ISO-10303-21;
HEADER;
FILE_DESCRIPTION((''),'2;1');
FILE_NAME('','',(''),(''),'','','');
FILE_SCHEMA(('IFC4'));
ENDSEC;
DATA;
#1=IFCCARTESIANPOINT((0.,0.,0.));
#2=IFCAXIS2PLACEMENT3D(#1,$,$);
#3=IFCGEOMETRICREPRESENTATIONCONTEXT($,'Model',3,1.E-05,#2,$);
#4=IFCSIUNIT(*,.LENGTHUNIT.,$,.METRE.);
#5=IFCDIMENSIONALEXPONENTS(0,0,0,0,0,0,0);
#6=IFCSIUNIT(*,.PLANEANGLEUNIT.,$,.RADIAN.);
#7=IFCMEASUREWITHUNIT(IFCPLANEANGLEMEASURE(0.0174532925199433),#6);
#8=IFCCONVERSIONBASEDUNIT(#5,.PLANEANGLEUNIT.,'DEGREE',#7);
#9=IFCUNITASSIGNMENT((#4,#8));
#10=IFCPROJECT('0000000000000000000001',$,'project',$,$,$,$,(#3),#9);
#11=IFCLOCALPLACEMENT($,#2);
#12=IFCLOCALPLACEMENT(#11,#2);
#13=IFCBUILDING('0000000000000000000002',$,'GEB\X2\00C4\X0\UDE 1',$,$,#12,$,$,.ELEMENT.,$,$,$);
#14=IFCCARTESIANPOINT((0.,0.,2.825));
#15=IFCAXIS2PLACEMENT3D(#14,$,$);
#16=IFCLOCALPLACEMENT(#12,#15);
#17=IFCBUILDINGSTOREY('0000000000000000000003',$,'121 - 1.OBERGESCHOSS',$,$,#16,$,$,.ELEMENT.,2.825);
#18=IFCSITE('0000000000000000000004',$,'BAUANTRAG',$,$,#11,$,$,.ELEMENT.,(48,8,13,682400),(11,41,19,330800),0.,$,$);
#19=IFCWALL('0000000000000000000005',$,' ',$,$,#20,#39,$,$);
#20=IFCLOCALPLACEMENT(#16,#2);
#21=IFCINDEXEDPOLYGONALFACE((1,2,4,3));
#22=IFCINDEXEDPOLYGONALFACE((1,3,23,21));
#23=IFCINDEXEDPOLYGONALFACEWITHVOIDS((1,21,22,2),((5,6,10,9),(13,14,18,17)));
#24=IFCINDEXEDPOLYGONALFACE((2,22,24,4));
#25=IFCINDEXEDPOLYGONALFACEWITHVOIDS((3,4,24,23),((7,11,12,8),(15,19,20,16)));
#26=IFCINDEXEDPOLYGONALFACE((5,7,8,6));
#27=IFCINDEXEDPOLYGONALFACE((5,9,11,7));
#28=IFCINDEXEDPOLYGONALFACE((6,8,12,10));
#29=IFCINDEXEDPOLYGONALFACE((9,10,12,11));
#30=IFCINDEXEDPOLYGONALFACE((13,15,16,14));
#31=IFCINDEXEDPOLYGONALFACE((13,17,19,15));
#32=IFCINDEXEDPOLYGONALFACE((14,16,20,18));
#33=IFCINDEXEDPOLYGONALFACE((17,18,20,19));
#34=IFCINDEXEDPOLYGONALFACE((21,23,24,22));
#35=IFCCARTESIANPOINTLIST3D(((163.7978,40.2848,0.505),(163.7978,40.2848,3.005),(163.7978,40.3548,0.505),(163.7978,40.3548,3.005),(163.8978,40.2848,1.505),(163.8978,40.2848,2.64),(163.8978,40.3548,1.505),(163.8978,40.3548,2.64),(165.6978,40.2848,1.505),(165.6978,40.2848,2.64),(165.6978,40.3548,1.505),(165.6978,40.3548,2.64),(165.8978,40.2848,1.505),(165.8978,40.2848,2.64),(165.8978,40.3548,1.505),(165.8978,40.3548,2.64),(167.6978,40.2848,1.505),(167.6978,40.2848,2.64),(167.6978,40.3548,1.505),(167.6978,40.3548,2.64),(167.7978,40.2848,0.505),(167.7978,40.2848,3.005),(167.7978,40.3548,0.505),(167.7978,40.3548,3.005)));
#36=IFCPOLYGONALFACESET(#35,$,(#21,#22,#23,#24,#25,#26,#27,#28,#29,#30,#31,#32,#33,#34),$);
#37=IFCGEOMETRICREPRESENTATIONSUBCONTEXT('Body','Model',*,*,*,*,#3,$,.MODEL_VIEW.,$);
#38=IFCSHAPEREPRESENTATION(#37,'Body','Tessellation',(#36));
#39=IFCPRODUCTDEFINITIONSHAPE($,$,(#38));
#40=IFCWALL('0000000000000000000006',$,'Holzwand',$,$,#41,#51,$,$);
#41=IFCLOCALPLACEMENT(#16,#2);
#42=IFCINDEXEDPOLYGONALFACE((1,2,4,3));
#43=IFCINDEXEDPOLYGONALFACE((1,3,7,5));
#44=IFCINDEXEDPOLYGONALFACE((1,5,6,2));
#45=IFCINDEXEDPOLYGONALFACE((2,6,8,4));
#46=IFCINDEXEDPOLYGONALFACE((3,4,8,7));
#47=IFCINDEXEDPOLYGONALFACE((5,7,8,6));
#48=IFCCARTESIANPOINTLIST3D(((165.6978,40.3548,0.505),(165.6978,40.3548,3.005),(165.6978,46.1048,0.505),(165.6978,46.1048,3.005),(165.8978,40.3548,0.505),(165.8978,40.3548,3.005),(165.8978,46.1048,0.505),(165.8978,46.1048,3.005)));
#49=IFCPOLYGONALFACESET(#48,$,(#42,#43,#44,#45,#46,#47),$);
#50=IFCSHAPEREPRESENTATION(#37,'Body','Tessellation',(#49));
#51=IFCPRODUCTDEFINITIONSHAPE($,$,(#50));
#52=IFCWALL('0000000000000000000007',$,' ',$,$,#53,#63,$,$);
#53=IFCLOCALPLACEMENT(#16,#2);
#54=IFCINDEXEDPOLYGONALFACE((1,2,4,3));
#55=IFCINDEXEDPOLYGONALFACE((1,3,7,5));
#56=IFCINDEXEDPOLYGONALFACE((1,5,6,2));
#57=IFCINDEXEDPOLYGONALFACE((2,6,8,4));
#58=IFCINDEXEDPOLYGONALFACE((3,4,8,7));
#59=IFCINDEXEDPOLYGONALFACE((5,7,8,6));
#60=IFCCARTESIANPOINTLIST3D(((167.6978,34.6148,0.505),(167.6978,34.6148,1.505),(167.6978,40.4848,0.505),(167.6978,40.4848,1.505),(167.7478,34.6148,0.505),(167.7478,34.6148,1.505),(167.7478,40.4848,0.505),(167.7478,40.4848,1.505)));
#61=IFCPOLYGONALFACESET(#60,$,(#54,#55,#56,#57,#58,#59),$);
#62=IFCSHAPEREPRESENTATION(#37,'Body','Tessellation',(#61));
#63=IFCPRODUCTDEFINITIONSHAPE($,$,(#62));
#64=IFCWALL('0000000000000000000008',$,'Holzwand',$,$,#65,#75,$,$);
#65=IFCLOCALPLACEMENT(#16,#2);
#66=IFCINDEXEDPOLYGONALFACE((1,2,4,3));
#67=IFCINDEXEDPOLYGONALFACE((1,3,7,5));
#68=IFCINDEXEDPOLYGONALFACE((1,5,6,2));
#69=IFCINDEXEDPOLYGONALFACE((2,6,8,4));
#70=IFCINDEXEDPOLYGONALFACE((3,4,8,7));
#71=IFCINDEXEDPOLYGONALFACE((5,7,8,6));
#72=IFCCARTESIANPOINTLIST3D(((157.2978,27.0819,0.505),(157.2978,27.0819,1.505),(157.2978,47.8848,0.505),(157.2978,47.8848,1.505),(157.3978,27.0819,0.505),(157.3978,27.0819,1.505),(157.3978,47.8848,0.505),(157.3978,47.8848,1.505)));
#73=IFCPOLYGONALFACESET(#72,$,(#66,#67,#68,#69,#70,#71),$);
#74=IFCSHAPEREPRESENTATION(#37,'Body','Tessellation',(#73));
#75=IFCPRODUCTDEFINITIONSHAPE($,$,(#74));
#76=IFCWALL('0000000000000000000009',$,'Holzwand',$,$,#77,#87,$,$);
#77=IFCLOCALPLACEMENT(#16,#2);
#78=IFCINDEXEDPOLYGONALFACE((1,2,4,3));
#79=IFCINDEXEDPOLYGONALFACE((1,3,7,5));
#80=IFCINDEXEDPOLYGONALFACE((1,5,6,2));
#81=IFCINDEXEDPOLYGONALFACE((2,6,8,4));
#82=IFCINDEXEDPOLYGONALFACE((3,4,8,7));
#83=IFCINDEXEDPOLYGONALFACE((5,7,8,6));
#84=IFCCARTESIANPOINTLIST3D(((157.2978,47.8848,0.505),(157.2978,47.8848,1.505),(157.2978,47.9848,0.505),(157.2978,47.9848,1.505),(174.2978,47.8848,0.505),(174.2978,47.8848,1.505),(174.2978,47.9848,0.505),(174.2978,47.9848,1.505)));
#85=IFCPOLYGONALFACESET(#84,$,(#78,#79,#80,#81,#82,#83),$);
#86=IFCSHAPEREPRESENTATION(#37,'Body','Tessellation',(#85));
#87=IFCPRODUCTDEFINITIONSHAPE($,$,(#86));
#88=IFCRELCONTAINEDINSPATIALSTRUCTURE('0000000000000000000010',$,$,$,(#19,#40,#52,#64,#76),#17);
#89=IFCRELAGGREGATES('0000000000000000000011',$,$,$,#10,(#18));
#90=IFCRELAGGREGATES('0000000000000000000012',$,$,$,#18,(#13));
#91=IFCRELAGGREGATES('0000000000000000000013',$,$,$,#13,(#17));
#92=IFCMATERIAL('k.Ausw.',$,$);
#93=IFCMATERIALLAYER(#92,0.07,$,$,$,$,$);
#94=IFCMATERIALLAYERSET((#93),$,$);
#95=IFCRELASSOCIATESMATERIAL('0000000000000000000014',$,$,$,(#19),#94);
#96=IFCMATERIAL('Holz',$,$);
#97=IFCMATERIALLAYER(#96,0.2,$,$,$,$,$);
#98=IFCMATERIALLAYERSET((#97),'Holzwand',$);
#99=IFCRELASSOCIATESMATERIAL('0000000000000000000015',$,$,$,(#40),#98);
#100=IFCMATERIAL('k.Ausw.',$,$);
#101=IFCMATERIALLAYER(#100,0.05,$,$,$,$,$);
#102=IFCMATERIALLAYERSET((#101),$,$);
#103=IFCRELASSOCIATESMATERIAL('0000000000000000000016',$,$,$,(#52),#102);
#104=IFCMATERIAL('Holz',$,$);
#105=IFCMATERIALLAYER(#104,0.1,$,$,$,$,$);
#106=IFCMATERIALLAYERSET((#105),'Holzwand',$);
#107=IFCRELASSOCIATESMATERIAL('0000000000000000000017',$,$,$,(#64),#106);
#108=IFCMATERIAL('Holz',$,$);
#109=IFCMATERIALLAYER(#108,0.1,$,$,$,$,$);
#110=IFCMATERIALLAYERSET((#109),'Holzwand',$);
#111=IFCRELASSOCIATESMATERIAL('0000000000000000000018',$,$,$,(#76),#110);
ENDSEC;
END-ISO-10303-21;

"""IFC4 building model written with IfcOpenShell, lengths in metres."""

from ifc_helpers import new_model, entity, si_unit, converted_unit, frame, frame_2d, origin, origin_with_axes, place, context, subcontext, project, spatial, polyline, rectangle, outline, extrude, material, layer, layer_set, layer_usage, element, save


model = new_model("IFC4")

# Units and contexts
model_context = context("Model", 3, precision=1e-05, world=origin())
body_context = subcontext(model_context, "Body", "Model", "MODEL_VIEW")
ifc_project = project(units=[si_unit("LENGTHUNIT", "METRE"), converted_unit("PLANEANGLEUNIT", "DEGREE", entity("IfcPlaneAngleMeasure", 0.0174532925199433), si_unit("PLANEANGLEUNIT", "RADIAN"), dimensions=[0, 0, 0, 0, 0, 0, 0])], contexts=[model_context])

# Site, building, storey
site_placement = place(None, origin())
site = spatial("IfcSite", under=ifc_project, at=site_placement, Name="BAUANTRAG", CompositionType="ELEMENT", RefLatitude=(48, 8, 13, 682400), RefLongitude=(11, 41, 19, 330800), RefElevation=0.0)
building_placement = place(site_placement, origin())
building = spatial("IfcBuilding", under=site, at=building_placement, Name="GEBÄUDE 1", CompositionType="ELEMENT")
storey_placement = place(building_placement, frame((0.0, 0.0, 2.825)))
storey = spatial("IfcBuildingStorey", under=building, at=storey_placement, Name="121 - 1.OBERGESCHOSS", CompositionType="ELEMENT", Elevation=2.825)

# Wall, openings
ifc_material_1 = material(Name="k.Ausw.")
ifc_layer_1 = layer(ifc_material_1, 0.07)
ifc_layer_set_1 = layer_set([ifc_layer_1])
ifc_layer_usage_1 = layer_usage(ifc_layer_set_1, "AXIS2", "POSITIVE", 0.0)
wall_1_placement = place(storey_placement, frame((167.7978, 40.3548, 0.505), z_axis=(0.0, 0.0, 1.0), x_axis=(-1.0, 0.0, 0.0)))
wall_1 = element("IfcWall", 1, at=wall_1_placement, inside=storey, material=ifc_layer_usage_1, Name=" ", context=body_context, shape_type="SweptSolid", body=[
    extrude(rectangle(XDim=4.0, YDim=0.07, at=frame_2d((2.0, 0.035), x_axis=(1.0, 0.0))), origin_with_axes(), (0.0, 0.0, 1.0), 2.5),
])
opening_1_placement = place(wall_1_placement, frame((2.1, 0.0, 1.0), z_axis=(0.0, 1.0, 0.0), x_axis=(0.0, 0.0, 1.0)))
element("IfcOpeningElement", 2, at=opening_1_placement, cuts=wall_1, ObjectType="Opening", context=body_context, shape_type="SweptSolid", body=[
    extrude(outline(polyline([(0.0, 1.8), (1.135, 1.8), (1.135, 0.0), (0.0, 0.0), (0.0, 1.8)])), origin_with_axes(), (0.0, 0.0, 1.0), 0.07),
])
opening_2_placement = place(wall_1_placement, frame((0.1, 0.0, 1.0), z_axis=(0.0, 1.0, 0.0), x_axis=(0.0, 0.0, 1.0)))
element("IfcOpeningElement", 3, at=opening_2_placement, cuts=wall_1, ObjectType="Opening", context=body_context, shape_type="SweptSolid", body=[
    extrude(outline(polyline([(0.0, 1.8), (1.135, 1.8), (1.135, 0.0), (0.0, 0.0), (0.0, 1.8)])), origin_with_axes(), (0.0, 0.0, 1.0), 0.07),
])

# Walls
ifc_material_2 = material(Name="Holz")
ifc_layer_2 = layer(ifc_material_2, 0.2)
ifc_layer_set_2 = layer_set([ifc_layer_2], Name="Holzwand")
ifc_layer_usage_2 = layer_usage(ifc_layer_set_2, "AXIS2", "POSITIVE", 0.0)
wall_2_placement = place(storey_placement, frame((165.6978, 46.1048, 0.505), z_axis=(0.0, 0.0, 1.0), x_axis=(0.0, -1.0, 0.0)))
element("IfcWall", 4, at=wall_2_placement, inside=storey, material=ifc_layer_usage_2, Name="Holzwand", context=body_context, shape_type="SweptSolid", body=[
    extrude(rectangle(XDim=5.75, YDim=0.2, at=frame_2d((2.875, 0.1), x_axis=(1.0, 0.0))), origin_with_axes(), (0.0, 0.0, 1.0), 2.5),
])
ifc_material_3 = material(Name="k.Ausw.")
ifc_layer_3 = layer(ifc_material_3, 0.05)
ifc_layer_set_3 = layer_set([ifc_layer_3])
ifc_layer_usage_3 = layer_usage(ifc_layer_set_3, "AXIS2", "POSITIVE", 0.0)
wall_3_placement = place(storey_placement, frame((167.7478, 34.6148, 0.505), z_axis=(0.0, 0.0, 1.0), x_axis=(0.0, 1.0, 0.0)))
element("IfcWall", 5, at=wall_3_placement, inside=storey, material=ifc_layer_usage_3, Name=" ", context=body_context, shape_type="SweptSolid", body=[
    extrude(rectangle(XDim=5.87, YDim=0.05, at=frame_2d((2.935, 0.025), x_axis=(1.0, 0.0))), origin_with_axes(), (0.0, 0.0, 1.0), 1.0),
])
ifc_material_4 = material(Name="Holz")
ifc_layer_4 = layer(ifc_material_4, 0.1)
ifc_layer_set_4 = layer_set([ifc_layer_4], Name="Holzwand")
ifc_layer_usage_4 = layer_usage(ifc_layer_set_4, "AXIS2", "POSITIVE", 0.0)
wall_4_placement = place(storey_placement, frame((157.2978, 47.8848, 0.505), z_axis=(0.0, 0.0, 1.0), x_axis=(0.0, -1.0, 0.0)))
element("IfcWall", 6, at=wall_4_placement, inside=storey, material=ifc_layer_usage_4, Name="Holzwand", context=body_context, shape_type="SweptSolid", body=[
    extrude(rectangle(XDim=20.8029, YDim=0.1, at=frame_2d((10.4014, 0.05), x_axis=(1.0, 0.0))), origin_with_axes(), (0.0, 0.0, 1.0), 1.0),
])
ifc_material_5 = material(Name="Holz")
ifc_layer_5 = layer(ifc_material_5, 0.1)
ifc_layer_set_5 = layer_set([ifc_layer_5], Name="Holzwand")
ifc_layer_usage_5 = layer_usage(ifc_layer_set_5, "AXIS2", "POSITIVE", 0.0)
wall_5_placement = place(storey_placement, frame((174.2978, 47.9848, 0.505), z_axis=(0.0, 0.0, 1.0), x_axis=(-1.0, 0.0, 0.0)))
element("IfcWall", 7, at=wall_5_placement, inside=storey, material=ifc_layer_usage_5, Name="Holzwand", context=body_context, shape_type="SweptSolid", body=[
    extrude(rectangle(XDim=17.0, YDim=0.1, at=frame_2d((8.5, 0.05), x_axis=(1.0, 0.0))), origin_with_axes(), (0.0, 0.0, 1.0), 1.0),
])

save(model, "model.ifc")
